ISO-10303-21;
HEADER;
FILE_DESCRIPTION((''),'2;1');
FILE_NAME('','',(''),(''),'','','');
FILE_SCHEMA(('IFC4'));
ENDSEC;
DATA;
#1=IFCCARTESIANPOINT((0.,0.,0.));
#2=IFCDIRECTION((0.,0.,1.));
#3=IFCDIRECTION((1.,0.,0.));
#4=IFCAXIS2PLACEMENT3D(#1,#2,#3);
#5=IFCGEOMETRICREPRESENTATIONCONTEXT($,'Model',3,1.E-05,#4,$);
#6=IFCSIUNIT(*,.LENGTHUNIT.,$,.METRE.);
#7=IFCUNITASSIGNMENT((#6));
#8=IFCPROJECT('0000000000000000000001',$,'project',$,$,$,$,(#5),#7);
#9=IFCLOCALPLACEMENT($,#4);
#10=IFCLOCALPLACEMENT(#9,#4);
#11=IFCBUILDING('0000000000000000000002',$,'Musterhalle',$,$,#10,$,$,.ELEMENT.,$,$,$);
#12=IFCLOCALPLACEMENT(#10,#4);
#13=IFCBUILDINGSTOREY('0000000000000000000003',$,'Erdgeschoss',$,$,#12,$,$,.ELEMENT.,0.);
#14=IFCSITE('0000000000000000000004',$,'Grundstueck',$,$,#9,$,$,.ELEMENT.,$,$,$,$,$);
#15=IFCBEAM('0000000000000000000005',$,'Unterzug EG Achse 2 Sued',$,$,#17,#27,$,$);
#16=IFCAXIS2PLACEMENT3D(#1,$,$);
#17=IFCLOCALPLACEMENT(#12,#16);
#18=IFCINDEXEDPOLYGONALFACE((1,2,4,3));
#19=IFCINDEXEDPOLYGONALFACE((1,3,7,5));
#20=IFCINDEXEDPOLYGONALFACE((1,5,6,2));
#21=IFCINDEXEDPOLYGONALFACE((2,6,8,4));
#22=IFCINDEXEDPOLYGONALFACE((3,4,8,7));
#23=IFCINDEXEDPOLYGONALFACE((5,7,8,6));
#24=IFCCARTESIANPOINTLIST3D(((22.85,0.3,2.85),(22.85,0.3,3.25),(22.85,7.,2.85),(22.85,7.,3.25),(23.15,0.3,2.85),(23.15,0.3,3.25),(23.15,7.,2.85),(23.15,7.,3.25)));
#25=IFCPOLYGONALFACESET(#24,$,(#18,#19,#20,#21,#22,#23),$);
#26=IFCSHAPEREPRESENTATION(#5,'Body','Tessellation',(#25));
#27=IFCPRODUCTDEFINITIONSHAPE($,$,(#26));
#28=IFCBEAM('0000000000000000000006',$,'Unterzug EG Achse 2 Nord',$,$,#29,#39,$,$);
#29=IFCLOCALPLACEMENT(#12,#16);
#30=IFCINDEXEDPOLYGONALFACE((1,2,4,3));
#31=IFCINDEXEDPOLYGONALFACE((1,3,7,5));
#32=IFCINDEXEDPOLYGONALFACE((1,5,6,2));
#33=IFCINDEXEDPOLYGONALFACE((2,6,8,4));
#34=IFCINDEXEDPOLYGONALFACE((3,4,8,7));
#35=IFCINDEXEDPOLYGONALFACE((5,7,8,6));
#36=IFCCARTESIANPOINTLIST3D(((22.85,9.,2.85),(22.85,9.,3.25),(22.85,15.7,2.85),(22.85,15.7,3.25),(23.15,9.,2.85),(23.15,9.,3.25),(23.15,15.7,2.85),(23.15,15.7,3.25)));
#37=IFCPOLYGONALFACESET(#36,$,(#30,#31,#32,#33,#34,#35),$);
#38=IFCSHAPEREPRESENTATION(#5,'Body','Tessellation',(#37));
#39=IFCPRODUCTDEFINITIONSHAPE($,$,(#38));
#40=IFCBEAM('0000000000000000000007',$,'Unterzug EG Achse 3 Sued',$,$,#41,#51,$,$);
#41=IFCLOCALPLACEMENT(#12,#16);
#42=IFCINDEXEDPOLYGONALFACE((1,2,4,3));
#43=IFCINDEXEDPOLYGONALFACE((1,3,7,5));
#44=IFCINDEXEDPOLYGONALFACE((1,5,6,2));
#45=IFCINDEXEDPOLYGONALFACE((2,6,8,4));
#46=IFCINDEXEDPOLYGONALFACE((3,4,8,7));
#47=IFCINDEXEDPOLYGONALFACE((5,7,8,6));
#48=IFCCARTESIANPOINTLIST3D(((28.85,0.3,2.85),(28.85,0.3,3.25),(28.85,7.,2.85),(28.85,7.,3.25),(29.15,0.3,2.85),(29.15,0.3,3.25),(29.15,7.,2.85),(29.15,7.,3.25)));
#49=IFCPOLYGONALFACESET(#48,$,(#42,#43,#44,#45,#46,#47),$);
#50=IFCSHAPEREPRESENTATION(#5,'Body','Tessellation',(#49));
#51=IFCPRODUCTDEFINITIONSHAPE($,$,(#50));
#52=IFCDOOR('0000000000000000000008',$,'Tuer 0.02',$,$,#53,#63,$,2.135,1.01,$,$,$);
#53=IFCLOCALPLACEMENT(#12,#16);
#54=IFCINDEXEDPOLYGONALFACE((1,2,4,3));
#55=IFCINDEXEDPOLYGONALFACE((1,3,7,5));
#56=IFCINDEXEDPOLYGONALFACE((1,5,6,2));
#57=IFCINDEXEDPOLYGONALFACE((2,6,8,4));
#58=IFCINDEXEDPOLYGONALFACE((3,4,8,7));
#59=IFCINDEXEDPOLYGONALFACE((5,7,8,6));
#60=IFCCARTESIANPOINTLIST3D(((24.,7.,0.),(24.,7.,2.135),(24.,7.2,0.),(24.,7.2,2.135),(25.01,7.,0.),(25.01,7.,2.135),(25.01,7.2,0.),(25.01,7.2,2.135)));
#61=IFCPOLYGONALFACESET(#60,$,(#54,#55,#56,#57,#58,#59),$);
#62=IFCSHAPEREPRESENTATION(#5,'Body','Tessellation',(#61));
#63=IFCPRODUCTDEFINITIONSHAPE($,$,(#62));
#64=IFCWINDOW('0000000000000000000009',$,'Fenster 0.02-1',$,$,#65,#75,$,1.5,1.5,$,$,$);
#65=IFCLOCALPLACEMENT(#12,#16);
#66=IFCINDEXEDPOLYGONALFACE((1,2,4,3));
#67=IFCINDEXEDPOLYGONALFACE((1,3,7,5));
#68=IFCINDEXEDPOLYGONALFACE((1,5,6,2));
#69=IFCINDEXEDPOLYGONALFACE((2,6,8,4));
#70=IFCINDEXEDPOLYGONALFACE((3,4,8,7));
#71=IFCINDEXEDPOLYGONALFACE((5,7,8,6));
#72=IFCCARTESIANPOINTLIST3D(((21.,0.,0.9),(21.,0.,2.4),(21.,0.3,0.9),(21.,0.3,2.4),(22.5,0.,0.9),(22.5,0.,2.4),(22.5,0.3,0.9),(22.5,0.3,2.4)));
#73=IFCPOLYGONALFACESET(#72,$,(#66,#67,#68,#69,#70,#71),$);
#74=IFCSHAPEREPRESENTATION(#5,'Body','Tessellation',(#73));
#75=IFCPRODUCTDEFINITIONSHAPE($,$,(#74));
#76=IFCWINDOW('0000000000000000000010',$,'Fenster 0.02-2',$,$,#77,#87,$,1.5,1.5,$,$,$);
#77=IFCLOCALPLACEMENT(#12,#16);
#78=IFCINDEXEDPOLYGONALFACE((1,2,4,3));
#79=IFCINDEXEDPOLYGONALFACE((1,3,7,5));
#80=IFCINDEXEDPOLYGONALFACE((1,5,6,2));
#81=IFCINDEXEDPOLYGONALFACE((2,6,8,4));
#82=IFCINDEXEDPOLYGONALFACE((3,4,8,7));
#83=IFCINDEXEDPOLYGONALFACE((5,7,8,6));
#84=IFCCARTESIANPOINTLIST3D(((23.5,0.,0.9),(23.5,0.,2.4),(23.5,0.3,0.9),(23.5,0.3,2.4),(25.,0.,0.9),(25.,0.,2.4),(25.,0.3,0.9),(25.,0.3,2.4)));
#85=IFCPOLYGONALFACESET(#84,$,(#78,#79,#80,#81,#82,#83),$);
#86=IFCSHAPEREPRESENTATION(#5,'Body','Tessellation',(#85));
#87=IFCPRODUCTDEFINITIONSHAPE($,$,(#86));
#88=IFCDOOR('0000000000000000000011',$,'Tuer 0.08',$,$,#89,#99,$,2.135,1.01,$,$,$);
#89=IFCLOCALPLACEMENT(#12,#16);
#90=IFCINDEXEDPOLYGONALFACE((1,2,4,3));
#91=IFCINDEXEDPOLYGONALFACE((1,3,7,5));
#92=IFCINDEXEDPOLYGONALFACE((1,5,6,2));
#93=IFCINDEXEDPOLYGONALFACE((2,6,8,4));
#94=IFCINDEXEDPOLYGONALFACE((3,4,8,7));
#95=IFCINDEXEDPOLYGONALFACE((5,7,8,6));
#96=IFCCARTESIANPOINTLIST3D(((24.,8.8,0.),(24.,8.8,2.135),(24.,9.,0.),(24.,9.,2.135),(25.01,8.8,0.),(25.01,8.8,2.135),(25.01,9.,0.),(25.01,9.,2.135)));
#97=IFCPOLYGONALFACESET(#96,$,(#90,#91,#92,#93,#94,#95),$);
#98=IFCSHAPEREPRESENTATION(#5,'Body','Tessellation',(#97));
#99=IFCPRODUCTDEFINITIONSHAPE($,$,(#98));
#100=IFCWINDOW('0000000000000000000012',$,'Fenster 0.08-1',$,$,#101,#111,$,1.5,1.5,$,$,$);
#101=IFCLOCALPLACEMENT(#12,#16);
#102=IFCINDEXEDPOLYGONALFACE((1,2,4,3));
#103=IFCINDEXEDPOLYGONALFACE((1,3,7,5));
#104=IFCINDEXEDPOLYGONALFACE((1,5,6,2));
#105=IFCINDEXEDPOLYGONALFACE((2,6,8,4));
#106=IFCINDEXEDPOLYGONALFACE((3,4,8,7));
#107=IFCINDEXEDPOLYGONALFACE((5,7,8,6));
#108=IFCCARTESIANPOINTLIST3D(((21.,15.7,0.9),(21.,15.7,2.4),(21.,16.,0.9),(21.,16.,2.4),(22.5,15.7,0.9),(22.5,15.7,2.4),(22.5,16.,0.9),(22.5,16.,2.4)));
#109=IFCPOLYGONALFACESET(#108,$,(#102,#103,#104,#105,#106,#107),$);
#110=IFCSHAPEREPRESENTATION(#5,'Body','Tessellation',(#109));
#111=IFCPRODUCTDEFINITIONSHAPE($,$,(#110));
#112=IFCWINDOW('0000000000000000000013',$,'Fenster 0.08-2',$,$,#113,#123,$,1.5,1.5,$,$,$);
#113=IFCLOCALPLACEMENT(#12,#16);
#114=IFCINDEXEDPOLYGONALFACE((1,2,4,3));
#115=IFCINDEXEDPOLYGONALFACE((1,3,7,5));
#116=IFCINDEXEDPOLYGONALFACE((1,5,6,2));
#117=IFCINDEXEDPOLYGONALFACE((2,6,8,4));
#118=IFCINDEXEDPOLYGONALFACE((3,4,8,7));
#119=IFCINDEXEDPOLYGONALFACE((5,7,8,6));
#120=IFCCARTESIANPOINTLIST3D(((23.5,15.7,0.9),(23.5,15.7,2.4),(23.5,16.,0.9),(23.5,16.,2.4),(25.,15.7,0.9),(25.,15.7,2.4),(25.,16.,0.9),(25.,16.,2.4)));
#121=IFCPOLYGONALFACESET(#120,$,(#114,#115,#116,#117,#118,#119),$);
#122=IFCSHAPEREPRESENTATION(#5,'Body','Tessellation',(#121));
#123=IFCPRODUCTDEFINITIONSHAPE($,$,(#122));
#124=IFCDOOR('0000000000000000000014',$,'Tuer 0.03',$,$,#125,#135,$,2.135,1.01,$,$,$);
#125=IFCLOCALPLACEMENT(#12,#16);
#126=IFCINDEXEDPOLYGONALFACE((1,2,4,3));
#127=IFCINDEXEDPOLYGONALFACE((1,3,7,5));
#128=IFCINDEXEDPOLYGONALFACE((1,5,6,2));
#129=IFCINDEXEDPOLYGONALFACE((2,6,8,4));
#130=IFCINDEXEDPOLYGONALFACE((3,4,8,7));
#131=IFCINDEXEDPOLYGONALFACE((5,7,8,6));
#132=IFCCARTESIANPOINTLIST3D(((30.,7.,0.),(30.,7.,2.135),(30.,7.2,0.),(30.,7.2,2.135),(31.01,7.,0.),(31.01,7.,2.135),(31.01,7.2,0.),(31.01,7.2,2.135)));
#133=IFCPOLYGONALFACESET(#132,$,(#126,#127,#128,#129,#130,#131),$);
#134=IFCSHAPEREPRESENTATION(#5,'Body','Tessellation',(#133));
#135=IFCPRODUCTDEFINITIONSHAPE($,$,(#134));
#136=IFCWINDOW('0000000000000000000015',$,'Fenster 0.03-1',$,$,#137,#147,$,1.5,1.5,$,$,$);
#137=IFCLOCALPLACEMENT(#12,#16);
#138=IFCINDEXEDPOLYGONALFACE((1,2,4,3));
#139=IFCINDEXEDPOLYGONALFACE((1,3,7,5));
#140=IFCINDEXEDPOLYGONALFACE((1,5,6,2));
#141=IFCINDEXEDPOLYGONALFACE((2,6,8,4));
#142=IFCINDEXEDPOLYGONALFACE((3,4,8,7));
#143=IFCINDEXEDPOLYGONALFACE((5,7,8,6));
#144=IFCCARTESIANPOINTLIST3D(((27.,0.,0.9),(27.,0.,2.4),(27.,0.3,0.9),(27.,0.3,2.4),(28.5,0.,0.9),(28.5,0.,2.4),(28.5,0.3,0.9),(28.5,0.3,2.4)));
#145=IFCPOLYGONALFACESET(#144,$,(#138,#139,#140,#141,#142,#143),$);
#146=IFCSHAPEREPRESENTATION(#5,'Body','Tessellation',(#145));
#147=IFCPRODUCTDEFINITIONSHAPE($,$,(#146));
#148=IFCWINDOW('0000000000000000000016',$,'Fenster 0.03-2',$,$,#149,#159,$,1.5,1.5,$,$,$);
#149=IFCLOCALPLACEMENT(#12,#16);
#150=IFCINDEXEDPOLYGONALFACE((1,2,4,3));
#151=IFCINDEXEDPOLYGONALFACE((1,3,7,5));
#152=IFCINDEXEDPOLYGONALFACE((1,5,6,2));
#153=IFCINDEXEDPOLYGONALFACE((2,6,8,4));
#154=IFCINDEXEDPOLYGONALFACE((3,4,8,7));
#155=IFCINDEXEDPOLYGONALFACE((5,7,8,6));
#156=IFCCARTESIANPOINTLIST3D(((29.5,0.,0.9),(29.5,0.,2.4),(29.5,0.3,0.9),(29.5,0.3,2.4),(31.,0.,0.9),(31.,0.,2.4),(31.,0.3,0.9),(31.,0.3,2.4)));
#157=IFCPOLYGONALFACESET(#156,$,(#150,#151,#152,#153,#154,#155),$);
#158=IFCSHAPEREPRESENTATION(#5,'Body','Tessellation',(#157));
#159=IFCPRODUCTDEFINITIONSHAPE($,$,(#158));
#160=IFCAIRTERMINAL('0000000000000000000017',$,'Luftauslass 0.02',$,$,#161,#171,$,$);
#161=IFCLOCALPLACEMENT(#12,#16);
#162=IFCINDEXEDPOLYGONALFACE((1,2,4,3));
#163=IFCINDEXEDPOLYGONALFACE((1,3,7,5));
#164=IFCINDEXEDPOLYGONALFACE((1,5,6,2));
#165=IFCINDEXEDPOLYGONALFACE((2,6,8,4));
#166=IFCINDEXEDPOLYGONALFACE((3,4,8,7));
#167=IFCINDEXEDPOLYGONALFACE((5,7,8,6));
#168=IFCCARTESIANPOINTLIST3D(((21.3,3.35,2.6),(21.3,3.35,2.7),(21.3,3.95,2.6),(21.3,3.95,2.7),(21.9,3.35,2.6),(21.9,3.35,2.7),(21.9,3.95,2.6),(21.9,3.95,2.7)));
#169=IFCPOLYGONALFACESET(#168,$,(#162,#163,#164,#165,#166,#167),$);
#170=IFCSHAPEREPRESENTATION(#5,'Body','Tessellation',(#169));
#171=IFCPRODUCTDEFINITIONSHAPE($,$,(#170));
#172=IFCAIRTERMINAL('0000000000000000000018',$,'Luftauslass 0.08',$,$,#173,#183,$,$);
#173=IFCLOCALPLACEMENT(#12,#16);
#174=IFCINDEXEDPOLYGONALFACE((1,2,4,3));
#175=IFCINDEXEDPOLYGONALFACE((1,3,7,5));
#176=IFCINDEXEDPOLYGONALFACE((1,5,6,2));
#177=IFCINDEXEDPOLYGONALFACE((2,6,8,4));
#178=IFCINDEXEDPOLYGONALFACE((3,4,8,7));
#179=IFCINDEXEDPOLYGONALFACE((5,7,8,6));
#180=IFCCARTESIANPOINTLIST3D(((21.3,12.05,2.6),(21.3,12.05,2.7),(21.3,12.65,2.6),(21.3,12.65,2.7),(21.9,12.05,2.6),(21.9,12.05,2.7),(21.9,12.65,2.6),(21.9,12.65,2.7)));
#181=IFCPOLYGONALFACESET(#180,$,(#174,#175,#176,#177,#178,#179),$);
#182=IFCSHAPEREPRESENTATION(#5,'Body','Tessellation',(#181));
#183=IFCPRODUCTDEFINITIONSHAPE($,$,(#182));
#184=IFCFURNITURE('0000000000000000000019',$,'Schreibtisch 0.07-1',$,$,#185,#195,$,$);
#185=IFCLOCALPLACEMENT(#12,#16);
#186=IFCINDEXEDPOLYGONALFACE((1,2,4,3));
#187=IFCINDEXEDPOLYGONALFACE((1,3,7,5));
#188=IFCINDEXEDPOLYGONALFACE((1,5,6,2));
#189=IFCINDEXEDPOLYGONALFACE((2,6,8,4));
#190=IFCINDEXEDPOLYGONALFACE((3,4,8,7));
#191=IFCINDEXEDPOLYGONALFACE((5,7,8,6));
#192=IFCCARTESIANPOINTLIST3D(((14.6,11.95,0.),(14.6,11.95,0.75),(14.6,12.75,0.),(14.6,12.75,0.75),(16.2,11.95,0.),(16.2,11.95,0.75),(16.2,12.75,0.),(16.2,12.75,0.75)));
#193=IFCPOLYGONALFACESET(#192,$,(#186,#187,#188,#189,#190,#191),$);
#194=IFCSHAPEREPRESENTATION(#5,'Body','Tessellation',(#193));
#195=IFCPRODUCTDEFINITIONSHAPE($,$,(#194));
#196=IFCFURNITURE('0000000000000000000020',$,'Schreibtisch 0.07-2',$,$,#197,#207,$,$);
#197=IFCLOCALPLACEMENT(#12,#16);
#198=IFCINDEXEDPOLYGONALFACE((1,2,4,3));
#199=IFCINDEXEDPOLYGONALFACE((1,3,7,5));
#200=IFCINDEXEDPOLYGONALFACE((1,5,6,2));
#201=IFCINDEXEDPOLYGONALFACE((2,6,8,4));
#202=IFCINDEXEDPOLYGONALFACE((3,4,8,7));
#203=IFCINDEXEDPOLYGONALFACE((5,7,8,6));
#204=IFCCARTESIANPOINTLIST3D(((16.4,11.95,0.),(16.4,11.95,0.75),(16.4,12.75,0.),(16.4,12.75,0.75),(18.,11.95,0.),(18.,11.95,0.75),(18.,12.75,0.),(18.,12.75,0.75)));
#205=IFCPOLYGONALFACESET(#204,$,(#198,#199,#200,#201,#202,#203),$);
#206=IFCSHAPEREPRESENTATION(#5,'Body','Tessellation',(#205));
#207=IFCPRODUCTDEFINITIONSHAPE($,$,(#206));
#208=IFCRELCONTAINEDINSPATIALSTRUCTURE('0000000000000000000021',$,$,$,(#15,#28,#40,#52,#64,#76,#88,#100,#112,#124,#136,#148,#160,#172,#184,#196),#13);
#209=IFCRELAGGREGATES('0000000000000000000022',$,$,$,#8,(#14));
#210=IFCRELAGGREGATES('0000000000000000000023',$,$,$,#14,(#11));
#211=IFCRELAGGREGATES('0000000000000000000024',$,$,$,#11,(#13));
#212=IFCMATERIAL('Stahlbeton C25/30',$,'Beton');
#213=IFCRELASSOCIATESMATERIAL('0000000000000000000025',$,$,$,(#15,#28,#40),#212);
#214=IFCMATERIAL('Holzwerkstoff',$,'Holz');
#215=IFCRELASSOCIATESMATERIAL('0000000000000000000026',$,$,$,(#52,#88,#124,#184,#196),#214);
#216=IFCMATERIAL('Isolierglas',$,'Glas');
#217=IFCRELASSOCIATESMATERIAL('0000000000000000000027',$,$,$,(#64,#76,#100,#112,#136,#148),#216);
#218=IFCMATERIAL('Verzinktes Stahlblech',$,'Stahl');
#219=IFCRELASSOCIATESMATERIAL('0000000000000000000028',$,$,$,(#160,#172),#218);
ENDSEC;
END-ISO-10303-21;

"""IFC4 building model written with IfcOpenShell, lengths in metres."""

from ifc_helpers import new_model, si_unit, frame, origin_with_axes, origin_2d, place, context, project, spatial, rectangle, extrude, material, element, save


model = new_model("IFC4")

# Units and contexts
model_context = context("Model", 3, precision=1e-05, world=origin_with_axes())
ifc_project = project(units=[si_unit("LENGTHUNIT", "METRE")], contexts=[model_context])

# Site, building, storey
site_placement = place(None, origin_with_axes())
site = spatial("IfcSite", under=ifc_project, at=site_placement, Name="Grundstueck", CompositionType="ELEMENT")
building_placement = place(site_placement, origin_with_axes())
building = spatial("IfcBuilding", under=site, at=building_placement, Name="Musterhalle", CompositionType="ELEMENT")
storey_placement = place(building_placement, origin_with_axes())
storey = spatial("IfcBuildingStorey", under=building, at=storey_placement, Name="Erdgeschoss", CompositionType="ELEMENT", Elevation=0.0)

# Beams
ifc_material_1 = material(Name="Stahlbeton C25/30", Category="Beton")
placement = place(storey_placement, origin_with_axes())
element("IfcBeam", 1, at=placement, inside=storey, material=ifc_material_1, Name="Unterzug EG Achse 2 Sued", context=model_context, shape_type="SweptSolid", body=[
    extrude(rectangle(XDim=0.3, YDim=6.7, at=origin_2d()), frame((23.0, 3.65, 2.85), z_axis=(0.0, 0.0, 1.0), x_axis=(1.0, 0.0, 0.0)), (0.0, 0.0, 1.0), 0.4),
])
element("IfcBeam", 2, at=placement, inside=storey, material=ifc_material_1, Name="Unterzug EG Achse 2 Nord", context=model_context, shape_type="SweptSolid", body=[
    extrude(rectangle(XDim=0.3, YDim=6.7, at=origin_2d()), frame((23.0, 12.35, 2.85), z_axis=(0.0, 0.0, 1.0), x_axis=(1.0, 0.0, 0.0)), (0.0, 0.0, 1.0), 0.4),
])
element("IfcBeam", 3, at=placement, inside=storey, material=ifc_material_1, Name="Unterzug EG Achse 3 Sued", context=model_context, shape_type="SweptSolid", body=[
    extrude(rectangle(XDim=0.3, YDim=6.7, at=origin_2d()), frame((29.0, 3.65, 2.85), z_axis=(0.0, 0.0, 1.0), x_axis=(1.0, 0.0, 0.0)), (0.0, 0.0, 1.0), 0.4),
])

# Door
ifc_material_2 = material(Name="Holzwerkstoff", Category="Holz")
element("IfcDoor", 4, at=placement, inside=storey, material=ifc_material_2, Name="Tuer 0.02", OverallHeight=2.135, OverallWidth=1.01, context=model_context, shape_type="SweptSolid", body=[
    extrude(rectangle(XDim=1.01, YDim=0.2, at=origin_2d()), frame((24.505, 7.1, 0.0), z_axis=(0.0, 0.0, 1.0), x_axis=(1.0, 0.0, 0.0)), (0.0, 0.0, 1.0), 2.135),
])

# Windows
ifc_material_3 = material(Name="Isolierglas", Category="Glas")
element("IfcWindow", 5, at=placement, inside=storey, material=ifc_material_3, Name="Fenster 0.02-1", OverallHeight=1.5, OverallWidth=1.5, context=model_context, shape_type="SweptSolid", body=[
    extrude(rectangle(XDim=1.5, YDim=0.3, at=origin_2d()), frame((21.75, 0.15, 0.9), z_axis=(0.0, 0.0, 1.0), x_axis=(1.0, 0.0, 0.0)), (0.0, 0.0, 1.0), 1.5),
])
element("IfcWindow", 6, at=placement, inside=storey, material=ifc_material_3, Name="Fenster 0.02-2", OverallHeight=1.5, OverallWidth=1.5, context=model_context, shape_type="SweptSolid", body=[
    extrude(rectangle(XDim=1.5, YDim=0.3, at=origin_2d()), frame((24.25, 0.15, 0.9), z_axis=(0.0, 0.0, 1.0), x_axis=(1.0, 0.0, 0.0)), (0.0, 0.0, 1.0), 1.5),
])

# Door
element("IfcDoor", 7, at=placement, inside=storey, material=ifc_material_2, Name="Tuer 0.08", OverallHeight=2.135, OverallWidth=1.01, context=model_context, shape_type="SweptSolid", body=[
    extrude(rectangle(XDim=1.01, YDim=0.2, at=origin_2d()), frame((24.505, 8.9, 0.0), z_axis=(0.0, 0.0, 1.0), x_axis=(1.0, 0.0, 0.0)), (0.0, 0.0, 1.0), 2.135),
])

# Windows
element("IfcWindow", 8, at=placement, inside=storey, material=ifc_material_3, Name="Fenster 0.08-1", OverallHeight=1.5, OverallWidth=1.5, context=model_context, shape_type="SweptSolid", body=[
    extrude(rectangle(XDim=1.5, YDim=0.3, at=origin_2d()), frame((21.75, 15.85, 0.9), z_axis=(0.0, 0.0, 1.0), x_axis=(1.0, 0.0, 0.0)), (0.0, 0.0, 1.0), 1.5),
])
element("IfcWindow", 9, at=placement, inside=storey, material=ifc_material_3, Name="Fenster 0.08-2", OverallHeight=1.5, OverallWidth=1.5, context=model_context, shape_type="SweptSolid", body=[
    extrude(rectangle(XDim=1.5, YDim=0.3, at=origin_2d()), frame((24.25, 15.85, 0.9), z_axis=(0.0, 0.0, 1.0), x_axis=(1.0, 0.0, 0.0)), (0.0, 0.0, 1.0), 1.5),
])

# Door
element("IfcDoor", 10, at=placement, inside=storey, material=ifc_material_2, Name="Tuer 0.03", OverallHeight=2.135, OverallWidth=1.01, context=model_context, shape_type="SweptSolid", body=[
    extrude(rectangle(XDim=1.01, YDim=0.2, at=origin_2d()), frame((30.505, 7.1, 0.0), z_axis=(0.0, 0.0, 1.0), x_axis=(1.0, 0.0, 0.0)), (0.0, 0.0, 1.0), 2.135),
])

# Windows
element("IfcWindow", 11, at=placement, inside=storey, material=ifc_material_3, Name="Fenster 0.03-1", OverallHeight=1.5, OverallWidth=1.5, context=model_context, shape_type="SweptSolid", body=[
    extrude(rectangle(XDim=1.5, YDim=0.3, at=origin_2d()), frame((27.75, 0.15, 0.9), z_axis=(0.0, 0.0, 1.0), x_axis=(1.0, 0.0, 0.0)), (0.0, 0.0, 1.0), 1.5),
])
element("IfcWindow", 12, at=placement, inside=storey, material=ifc_material_3, Name="Fenster 0.03-2", OverallHeight=1.5, OverallWidth=1.5, context=model_context, shape_type="SweptSolid", body=[
    extrude(rectangle(XDim=1.5, YDim=0.3, at=origin_2d()), frame((30.25, 0.15, 0.9), z_axis=(0.0, 0.0, 1.0), x_axis=(1.0, 0.0, 0.0)), (0.0, 0.0, 1.0), 1.5),
])

# Air terminals
ifc_material_4 = material(Name="Verzinktes Stahlblech", Category="Stahl")
element("IfcAirTerminal", 13, at=placement, inside=storey, material=ifc_material_4, Name="Luftauslass 0.02", context=model_context, shape_type="SweptSolid", body=[
    extrude(rectangle(XDim=0.6, YDim=0.6, at=origin_2d()), frame((21.6, 3.65, 2.6), z_axis=(0.0, 0.0, 1.0), x_axis=(1.0, 0.0, 0.0)), (0.0, 0.0, 1.0), 0.1),
])
element("IfcAirTerminal", 14, at=placement, inside=storey, material=ifc_material_4, Name="Luftauslass 0.08", context=model_context, shape_type="SweptSolid", body=[
    extrude(rectangle(XDim=0.6, YDim=0.6, at=origin_2d()), frame((21.6, 12.35, 2.6), z_axis=(0.0, 0.0, 1.0), x_axis=(1.0, 0.0, 0.0)), (0.0, 0.0, 1.0), 0.1),
])

# Furniture
element("IfcFurniture", 15, at=placement, inside=storey, material=ifc_material_2, Name="Schreibtisch 0.07-1", context=model_context, shape_type="SweptSolid", body=[
    extrude(rectangle(XDim=1.6, YDim=0.8, at=origin_2d()), frame((15.4, 12.35, 0.0), z_axis=(0.0, 0.0, 1.0), x_axis=(1.0, 0.0, 0.0)), (0.0, 0.0, 1.0), 0.75),
])
element("IfcFurniture", 16, at=placement, inside=storey, material=ifc_material_2, Name="Schreibtisch 0.07-2", context=model_context, shape_type="SweptSolid", body=[
    extrude(rectangle(XDim=1.6, YDim=0.8, at=origin_2d()), frame((17.2, 12.35, 0.0), z_axis=(0.0, 0.0, 1.0), x_axis=(1.0, 0.0, 0.0)), (0.0, 0.0, 1.0), 0.75),
])

save(model, "model.ifc")
